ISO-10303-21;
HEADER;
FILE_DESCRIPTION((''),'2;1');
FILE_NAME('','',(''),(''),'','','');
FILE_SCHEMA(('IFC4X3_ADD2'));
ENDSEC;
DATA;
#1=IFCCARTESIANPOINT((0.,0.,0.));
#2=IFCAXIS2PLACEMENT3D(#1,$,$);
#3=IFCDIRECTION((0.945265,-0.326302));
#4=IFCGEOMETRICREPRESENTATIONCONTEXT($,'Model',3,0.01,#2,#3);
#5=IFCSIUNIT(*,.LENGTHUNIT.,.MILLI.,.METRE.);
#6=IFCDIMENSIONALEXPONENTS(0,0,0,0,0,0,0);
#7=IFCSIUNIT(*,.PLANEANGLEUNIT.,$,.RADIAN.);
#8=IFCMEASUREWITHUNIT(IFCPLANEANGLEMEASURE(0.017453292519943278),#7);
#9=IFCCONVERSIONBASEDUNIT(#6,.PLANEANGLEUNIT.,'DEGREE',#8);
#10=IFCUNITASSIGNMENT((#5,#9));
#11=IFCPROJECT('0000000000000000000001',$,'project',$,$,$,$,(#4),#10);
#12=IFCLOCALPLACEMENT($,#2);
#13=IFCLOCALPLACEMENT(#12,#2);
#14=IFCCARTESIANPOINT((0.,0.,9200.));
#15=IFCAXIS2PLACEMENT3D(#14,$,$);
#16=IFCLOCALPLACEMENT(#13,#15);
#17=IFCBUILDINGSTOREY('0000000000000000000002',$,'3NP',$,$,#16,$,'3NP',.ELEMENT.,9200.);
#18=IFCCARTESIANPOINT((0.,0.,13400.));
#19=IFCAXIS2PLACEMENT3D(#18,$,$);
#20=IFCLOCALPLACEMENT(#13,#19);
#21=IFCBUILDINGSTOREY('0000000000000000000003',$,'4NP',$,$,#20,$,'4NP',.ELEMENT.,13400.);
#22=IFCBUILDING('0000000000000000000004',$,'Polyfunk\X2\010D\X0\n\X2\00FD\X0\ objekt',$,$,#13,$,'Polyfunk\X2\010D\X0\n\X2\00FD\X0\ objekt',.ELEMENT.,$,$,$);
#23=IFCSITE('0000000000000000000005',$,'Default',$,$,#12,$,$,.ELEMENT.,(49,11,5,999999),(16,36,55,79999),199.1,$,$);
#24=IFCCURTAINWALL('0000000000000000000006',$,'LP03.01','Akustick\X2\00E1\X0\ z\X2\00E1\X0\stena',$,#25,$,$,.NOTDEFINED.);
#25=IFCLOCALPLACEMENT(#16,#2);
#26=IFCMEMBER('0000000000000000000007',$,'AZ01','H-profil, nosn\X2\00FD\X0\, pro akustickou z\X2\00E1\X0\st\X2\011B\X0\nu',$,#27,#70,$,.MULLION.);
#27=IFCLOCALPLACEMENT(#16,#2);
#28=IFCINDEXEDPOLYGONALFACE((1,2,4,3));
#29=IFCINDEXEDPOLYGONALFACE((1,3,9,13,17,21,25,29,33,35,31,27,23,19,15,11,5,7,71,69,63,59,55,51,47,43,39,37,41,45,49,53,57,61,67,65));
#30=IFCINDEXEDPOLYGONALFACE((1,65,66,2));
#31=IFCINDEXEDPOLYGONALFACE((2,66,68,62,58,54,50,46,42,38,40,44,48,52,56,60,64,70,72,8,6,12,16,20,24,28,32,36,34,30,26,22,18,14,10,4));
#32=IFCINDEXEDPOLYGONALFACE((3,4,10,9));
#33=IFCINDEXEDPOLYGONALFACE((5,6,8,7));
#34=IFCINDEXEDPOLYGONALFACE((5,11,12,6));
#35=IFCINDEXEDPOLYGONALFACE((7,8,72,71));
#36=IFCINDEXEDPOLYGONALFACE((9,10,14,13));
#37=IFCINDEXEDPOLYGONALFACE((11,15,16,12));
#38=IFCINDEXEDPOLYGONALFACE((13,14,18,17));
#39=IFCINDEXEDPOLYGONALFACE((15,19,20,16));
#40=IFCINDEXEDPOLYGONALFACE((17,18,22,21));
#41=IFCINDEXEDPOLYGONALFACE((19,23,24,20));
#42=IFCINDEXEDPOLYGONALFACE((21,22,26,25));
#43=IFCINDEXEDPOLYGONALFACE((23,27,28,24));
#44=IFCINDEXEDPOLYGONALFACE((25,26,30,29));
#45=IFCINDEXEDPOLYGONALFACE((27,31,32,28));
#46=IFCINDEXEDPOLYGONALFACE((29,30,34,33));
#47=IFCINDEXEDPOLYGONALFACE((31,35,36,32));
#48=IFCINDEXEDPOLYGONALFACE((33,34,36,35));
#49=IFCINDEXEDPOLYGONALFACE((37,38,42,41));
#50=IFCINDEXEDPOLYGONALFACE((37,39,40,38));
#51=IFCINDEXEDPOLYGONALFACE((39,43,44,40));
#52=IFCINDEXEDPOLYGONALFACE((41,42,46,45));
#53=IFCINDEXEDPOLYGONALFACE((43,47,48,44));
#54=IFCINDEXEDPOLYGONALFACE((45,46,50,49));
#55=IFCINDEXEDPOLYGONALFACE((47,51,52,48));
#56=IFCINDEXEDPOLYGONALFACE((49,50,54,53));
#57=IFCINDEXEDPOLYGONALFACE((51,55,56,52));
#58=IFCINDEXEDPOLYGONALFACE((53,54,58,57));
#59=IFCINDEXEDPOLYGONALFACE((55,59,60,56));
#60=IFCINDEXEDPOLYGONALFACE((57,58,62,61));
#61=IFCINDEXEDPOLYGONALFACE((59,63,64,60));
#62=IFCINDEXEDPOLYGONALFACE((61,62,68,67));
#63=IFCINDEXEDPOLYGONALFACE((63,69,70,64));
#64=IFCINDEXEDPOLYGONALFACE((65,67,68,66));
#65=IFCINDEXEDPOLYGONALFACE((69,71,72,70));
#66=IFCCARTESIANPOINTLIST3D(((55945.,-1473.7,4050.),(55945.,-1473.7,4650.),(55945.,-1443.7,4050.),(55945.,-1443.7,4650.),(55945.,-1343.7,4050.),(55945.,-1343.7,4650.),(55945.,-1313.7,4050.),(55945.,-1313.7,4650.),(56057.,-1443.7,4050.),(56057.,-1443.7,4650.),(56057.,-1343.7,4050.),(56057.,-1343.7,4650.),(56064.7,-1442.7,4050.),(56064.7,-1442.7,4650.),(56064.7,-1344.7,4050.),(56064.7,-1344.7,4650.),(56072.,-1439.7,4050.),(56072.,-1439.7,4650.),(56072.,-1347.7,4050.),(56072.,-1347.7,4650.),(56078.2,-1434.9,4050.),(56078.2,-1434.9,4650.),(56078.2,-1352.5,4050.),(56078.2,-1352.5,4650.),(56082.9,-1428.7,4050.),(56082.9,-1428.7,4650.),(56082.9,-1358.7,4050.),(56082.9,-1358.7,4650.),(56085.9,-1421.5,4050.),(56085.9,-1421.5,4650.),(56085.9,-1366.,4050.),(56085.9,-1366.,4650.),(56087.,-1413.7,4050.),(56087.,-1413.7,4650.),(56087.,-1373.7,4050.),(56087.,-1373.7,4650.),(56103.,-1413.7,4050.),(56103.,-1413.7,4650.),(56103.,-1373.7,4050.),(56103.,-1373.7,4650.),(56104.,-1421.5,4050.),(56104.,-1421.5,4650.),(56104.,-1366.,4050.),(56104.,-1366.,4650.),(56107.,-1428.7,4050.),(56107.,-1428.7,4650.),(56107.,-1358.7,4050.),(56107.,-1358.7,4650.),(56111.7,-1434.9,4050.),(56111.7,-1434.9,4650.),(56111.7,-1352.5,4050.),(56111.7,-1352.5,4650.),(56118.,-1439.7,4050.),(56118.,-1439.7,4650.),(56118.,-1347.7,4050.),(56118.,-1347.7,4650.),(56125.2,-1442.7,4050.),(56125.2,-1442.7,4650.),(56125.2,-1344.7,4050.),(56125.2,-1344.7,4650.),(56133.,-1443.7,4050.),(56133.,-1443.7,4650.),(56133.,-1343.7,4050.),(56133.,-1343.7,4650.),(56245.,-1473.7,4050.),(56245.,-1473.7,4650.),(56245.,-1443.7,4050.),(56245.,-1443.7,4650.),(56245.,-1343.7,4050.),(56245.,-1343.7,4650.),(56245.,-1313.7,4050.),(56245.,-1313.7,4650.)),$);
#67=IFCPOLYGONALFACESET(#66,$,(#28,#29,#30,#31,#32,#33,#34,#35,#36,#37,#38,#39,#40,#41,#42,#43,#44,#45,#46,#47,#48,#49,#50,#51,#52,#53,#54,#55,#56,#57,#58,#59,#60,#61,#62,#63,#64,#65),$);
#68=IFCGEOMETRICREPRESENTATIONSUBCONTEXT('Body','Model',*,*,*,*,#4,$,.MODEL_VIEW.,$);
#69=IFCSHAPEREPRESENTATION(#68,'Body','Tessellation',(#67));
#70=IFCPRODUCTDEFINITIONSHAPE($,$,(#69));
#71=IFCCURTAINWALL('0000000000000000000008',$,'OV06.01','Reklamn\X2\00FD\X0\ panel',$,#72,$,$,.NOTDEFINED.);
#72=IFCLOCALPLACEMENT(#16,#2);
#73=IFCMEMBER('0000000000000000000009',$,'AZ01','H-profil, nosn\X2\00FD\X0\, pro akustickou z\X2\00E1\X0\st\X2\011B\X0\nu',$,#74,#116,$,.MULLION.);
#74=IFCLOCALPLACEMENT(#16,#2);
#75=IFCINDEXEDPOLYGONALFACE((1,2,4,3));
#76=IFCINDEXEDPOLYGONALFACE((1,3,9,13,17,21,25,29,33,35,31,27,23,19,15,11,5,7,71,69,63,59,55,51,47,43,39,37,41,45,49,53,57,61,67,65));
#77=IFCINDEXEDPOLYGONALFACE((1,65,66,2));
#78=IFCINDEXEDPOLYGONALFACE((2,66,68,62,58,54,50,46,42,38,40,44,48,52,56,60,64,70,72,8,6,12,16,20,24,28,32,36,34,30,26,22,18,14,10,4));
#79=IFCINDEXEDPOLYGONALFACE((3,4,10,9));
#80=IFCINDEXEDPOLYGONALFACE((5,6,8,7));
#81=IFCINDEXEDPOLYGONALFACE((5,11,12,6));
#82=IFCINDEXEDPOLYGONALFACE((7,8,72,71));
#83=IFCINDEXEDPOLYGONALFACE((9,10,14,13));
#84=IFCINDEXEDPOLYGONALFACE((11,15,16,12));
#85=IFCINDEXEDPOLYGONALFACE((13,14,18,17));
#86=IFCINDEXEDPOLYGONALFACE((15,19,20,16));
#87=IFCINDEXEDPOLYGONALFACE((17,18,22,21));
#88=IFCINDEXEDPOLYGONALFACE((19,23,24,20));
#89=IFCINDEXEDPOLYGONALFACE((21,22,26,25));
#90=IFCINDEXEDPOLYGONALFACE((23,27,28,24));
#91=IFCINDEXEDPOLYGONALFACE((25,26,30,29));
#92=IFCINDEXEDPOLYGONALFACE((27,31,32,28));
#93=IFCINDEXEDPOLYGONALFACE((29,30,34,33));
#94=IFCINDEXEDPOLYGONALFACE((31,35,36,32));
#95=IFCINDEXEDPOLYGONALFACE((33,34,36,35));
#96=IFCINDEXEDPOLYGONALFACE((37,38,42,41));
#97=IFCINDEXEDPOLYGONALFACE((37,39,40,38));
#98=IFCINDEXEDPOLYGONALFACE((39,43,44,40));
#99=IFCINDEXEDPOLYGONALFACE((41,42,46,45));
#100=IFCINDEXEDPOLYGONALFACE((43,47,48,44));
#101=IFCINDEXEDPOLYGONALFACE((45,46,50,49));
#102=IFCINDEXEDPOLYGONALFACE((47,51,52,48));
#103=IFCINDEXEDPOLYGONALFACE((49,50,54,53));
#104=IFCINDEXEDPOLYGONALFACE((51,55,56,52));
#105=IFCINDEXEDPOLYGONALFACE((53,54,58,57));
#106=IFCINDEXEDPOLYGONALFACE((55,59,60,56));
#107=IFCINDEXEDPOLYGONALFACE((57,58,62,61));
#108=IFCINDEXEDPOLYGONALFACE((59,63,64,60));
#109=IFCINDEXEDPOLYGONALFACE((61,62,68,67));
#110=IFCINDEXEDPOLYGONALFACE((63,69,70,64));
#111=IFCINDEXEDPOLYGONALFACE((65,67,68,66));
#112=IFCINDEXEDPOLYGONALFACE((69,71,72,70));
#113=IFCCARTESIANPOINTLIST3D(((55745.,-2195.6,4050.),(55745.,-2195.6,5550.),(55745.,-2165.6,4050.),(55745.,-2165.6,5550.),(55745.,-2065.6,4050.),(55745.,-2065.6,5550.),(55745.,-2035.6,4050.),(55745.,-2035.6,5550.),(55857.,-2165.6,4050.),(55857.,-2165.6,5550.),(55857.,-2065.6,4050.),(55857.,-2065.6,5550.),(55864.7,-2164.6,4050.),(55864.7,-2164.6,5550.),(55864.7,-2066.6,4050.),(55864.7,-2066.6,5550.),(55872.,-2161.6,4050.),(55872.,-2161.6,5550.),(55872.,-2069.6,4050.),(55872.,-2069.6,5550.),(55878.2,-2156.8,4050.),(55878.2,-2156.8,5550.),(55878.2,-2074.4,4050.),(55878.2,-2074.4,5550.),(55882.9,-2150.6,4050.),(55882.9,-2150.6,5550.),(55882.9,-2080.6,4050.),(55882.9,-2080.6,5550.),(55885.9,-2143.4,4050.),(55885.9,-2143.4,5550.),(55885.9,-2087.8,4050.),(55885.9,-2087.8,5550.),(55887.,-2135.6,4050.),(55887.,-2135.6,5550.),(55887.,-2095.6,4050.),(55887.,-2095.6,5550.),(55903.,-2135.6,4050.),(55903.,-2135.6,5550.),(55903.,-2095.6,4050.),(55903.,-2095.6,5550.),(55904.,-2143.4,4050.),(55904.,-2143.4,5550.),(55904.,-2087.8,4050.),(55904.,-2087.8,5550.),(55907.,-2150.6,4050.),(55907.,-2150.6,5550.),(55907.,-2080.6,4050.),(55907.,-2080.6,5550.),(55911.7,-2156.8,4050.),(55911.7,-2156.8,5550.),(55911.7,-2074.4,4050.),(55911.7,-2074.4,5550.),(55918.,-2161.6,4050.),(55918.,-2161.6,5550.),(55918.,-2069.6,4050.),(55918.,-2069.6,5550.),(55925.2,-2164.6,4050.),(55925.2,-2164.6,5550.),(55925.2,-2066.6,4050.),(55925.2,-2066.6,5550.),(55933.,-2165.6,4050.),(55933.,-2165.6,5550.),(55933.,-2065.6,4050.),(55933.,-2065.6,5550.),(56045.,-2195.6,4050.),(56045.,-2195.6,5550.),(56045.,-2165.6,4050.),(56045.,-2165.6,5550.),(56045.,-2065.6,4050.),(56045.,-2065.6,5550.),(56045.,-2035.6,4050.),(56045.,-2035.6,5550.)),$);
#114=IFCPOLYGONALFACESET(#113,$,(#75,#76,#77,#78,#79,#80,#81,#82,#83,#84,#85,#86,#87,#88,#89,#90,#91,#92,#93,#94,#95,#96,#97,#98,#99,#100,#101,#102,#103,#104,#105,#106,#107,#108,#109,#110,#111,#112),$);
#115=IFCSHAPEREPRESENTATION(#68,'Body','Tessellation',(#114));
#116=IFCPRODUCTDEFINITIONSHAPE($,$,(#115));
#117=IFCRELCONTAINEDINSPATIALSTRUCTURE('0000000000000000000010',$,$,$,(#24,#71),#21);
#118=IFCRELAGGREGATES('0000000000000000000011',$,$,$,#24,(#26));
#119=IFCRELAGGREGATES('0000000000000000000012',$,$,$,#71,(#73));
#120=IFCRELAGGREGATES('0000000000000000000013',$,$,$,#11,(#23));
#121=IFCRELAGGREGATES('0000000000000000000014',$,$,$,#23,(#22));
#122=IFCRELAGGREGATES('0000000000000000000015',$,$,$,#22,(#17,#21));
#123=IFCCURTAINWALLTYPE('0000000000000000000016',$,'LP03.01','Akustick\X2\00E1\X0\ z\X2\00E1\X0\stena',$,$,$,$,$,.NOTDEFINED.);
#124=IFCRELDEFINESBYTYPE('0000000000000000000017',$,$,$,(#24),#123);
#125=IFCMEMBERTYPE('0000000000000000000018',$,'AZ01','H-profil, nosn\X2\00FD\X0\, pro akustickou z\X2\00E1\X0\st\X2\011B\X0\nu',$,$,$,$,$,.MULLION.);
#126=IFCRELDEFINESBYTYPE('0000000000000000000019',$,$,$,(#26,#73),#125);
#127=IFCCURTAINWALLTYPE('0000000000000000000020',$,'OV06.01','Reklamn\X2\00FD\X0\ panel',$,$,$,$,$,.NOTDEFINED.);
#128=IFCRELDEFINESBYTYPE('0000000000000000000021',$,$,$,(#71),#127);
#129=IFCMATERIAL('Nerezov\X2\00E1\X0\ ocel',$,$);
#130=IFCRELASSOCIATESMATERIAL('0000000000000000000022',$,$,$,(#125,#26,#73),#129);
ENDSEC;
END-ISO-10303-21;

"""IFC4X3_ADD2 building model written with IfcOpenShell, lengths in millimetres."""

from ifc_helpers import new_model, entity, si_unit, converted_unit, direction, frame, frame_2d, origin, place, context, subcontext, project, spatial, polyline, circle_curve, parameter, trimmed, segment, composite_curve, outline, extrude, source, transform, mapped, material, material_profile, profile_set, profile_usage, type_object, element, aggregate, save


model = new_model("IFC4X3_ADD2")

# Units and contexts
model_context = context("Model", 3, precision=0.01, world=origin(), true_north=direction((0.945265, -0.326302)))
body_context = subcontext(model_context, "Body", "Model", "MODEL_VIEW")
ifc_project = project(units=[si_unit("LENGTHUNIT", "METRE", prefix="MILLI"), converted_unit("PLANEANGLEUNIT", "DEGREE", entity("IfcPlaneAngleMeasure", 0.017453292519943278), si_unit("PLANEANGLEUNIT", "RADIAN"), dimensions=[0, 0, 0, 0, 0, 0, 0])], contexts=[model_context])

# Site, building, storey
site_placement = place(None, origin())
site = spatial("IfcSite", under=ifc_project, at=site_placement, Name="Default", CompositionType="ELEMENT", RefLatitude=(49, 11, 5, 999999), RefLongitude=(16, 36, 55, 79999), RefElevation=199.1)
building_placement = place(site_placement, origin())
building = spatial("IfcBuilding", under=site, at=building_placement, Name="Polyfunkčný objekt", LongName="Polyfunkčný objekt", CompositionType="ELEMENT")
storey_1_placement = place(building_placement, frame((0.0, 0.0, 9200.0)))
storey_1 = spatial("IfcBuildingStorey", under=building, at=storey_1_placement, Name="3NP", LongName="3NP", CompositionType="ELEMENT", Elevation=9200.0)

# Shared definitions
storey_2_placement = place(building_placement, frame((0.0, 0.0, 13400.0)))
storey_2 = spatial("IfcBuildingStorey", under=building, at=storey_2_placement, Name="4NP", LongName="4NP", CompositionType="ELEMENT", Elevation=13400.0)

# Curtain walls, members
curtain_wall_type_1 = type_object("IfcCurtainWallType", Name="LP03.01", Description="Akustická zástena", PredefinedType="NOTDEFINED")
ifc_material_1 = material(Name="Nerezová ocel")
ifc_material_profile_1 = material_profile(ifc_material_1, outline(composite_curve([segment(polyline([(50.0, -150.0), (80.0, -150.0)]), True, "CONTINUOUS"), segment(polyline([(80.0, -150.0), (80.0, 150.0)]), True, "CONTINUOUS"), segment(polyline([(80.0, 150.0), (50.0, 150.0)]), True, "CONTINUOUS"), segment(polyline([(50.0, 150.0), (50.0, 38.0)]), True, "CONTINUOUS"), segment(trimmed(circle_curve(frame_2d((20.0, 38.0), x_axis=(0.0, 1.0)), 30.0), [parameter(180.0)], [parameter(270.0)], True, "PARAMETER"), False, "CONTINUOUS"), segment(polyline([(20.0, 8.0), (-20.0, 8.0)]), True, "CONTINUOUS"), segment(trimmed(circle_curve(frame_2d((-20.0, 38.0), x_axis=(0.0, 1.0)), 30.0), [parameter(90.0)], [parameter(180.0)], True, "PARAMETER"), False, "CONTINUOUS"), segment(polyline([(-50.0, 38.0), (-50.0, 150.0)]), True, "CONTINUOUS"), segment(polyline([(-50.0, 150.0), (-80.0, 150.0)]), True, "CONTINUOUS"), segment(polyline([(-80.0, 150.0), (-80.0, -150.0)]), True, "CONTINUOUS"), segment(polyline([(-80.0, -150.0), (-50.0, -150.0)]), True, "CONTINUOUS"), segment(polyline([(-50.0, -150.0), (-50.0, -38.0)]), True, "CONTINUOUS"), segment(trimmed(circle_curve(frame_2d((-20.0, -38.0), x_axis=(0.0, 1.0)), 30.0), [parameter(0.0)], [parameter(90.0)], True, "PARAMETER"), False, "CONTINUOUS"), segment(polyline([(-20.0, -8.0), (20.0, -8.0)]), True, "CONTINUOUS"), segment(trimmed(circle_curve(frame_2d((20.0, -38.0), x_axis=(0.0, 1.0)), 30.0), [parameter(270.0)], [parameter(0.0)], True, "PARAMETER"), False, "CONTINUOUS"), segment(polyline([(50.0, -38.0), (50.0, -150.0)]), True, "CONTINUOUS")], self_intersect=False)), Name="Profil zástena")
ifc_profile_set_1 = profile_set([ifc_material_profile_1], Name="Profil zástena")
ifc_profile_usage_1 = profile_usage(ifc_profile_set_1)
member_type_1 = type_object("IfcMemberType", Name="AZ01", Description="H-profil, nosný, pro akustickou zástěnu", PredefinedType="MULLION", material=ifc_profile_set_1)
curtain_wall_1_placement = place(storey_2_placement, frame((0.0, 0.0, -13400.0)))
curtain_wall_1 = element("IfcCurtainWall", 1, at=curtain_wall_1_placement, inside=storey_2, type_object=curtain_wall_type_1, Name="LP03.01", Description="Akustická zástena", PredefinedType="NOTDEFINED")
shared_shape_1 = source(origin(), body_context, "Body", "SweptSolid", [
    extrude(outline(composite_curve([segment(polyline([(50.0, -150.0), (80.0, -150.0)]), True, "CONTINUOUS"), segment(polyline([(80.0, -150.0), (80.0, 150.0)]), True, "CONTINUOUS"), segment(polyline([(80.0, 150.0), (50.0, 150.0)]), True, "CONTINUOUS"), segment(polyline([(50.0, 150.0), (50.0, 38.0)]), True, "CONTINUOUS"), segment(trimmed(circle_curve(frame_2d((20.0, 38.0), x_axis=(0.0, 1.0)), 30.0), [parameter(180.0)], [parameter(270.0)], True, "PARAMETER"), False, "CONTINUOUS"), segment(polyline([(20.0, 8.0), (-20.0, 8.0)]), True, "CONTINUOUS"), segment(trimmed(circle_curve(frame_2d((-20.0, 38.0), x_axis=(0.0, 1.0)), 30.0), [parameter(90.0)], [parameter(180.0)], True, "PARAMETER"), False, "CONTINUOUS"), segment(polyline([(-50.0, 38.0), (-50.0, 150.0)]), True, "CONTINUOUS"), segment(polyline([(-50.0, 150.0), (-80.0, 150.0)]), True, "CONTINUOUS"), segment(polyline([(-80.0, 150.0), (-80.0, -150.0)]), True, "CONTINUOUS"), segment(polyline([(-80.0, -150.0), (-50.0, -150.0)]), True, "CONTINUOUS"), segment(polyline([(-50.0, -150.0), (-50.0, -38.0)]), True, "CONTINUOUS"), segment(trimmed(circle_curve(frame_2d((-20.0, -38.0), x_axis=(0.0, 1.0)), 30.0), [parameter(0.0)], [parameter(90.0)], True, "PARAMETER"), False, "CONTINUOUS"), segment(polyline([(-20.0, -8.0), (20.0, -8.0)]), True, "CONTINUOUS"), segment(trimmed(circle_curve(frame_2d((20.0, -38.0), x_axis=(0.0, 1.0)), 30.0), [parameter(270.0)], [parameter(0.0)], True, "PARAMETER"), False, "CONTINUOUS"), segment(polyline([(50.0, -38.0), (50.0, -150.0)]), True, "CONTINUOUS")], self_intersect=False)), frame((-150.0, 0.0, -600.0), z_axis=(0.0, 0.0, 1.0), x_axis=(0.0, -1.0, 0.0)), (0.0, 0.0, 1.0), 600.0),
])
member_1_placement = place(curtain_wall_1_placement, frame((56245.0, -1393.7, 13250.0), z_axis=(0.0, 0.0, -1.0), x_axis=(1.0, 0.0, 0.0)))
member_1 = element("IfcMember", 2, at=member_1_placement, type_object=member_type_1, material=ifc_profile_usage_1, Name="AZ01", Description="H-profil, nosný, pro akustickou zástěnu", PredefinedType="MULLION", context=body_context, shape_type="MappedRepresentation", body=[
    mapped(shared_shape_1, transform((0.0, 0.0, 0.0), scale=1.0)),
])
aggregate(curtain_wall_1, [member_1])
curtain_wall_type_2 = type_object("IfcCurtainWallType", Name="OV06.01", Description="Reklamný panel", PredefinedType="NOTDEFINED")
curtain_wall_2_placement = place(storey_2_placement, frame((0.0, 0.0, -13400.0)))
curtain_wall_2 = element("IfcCurtainWall", 3, at=curtain_wall_2_placement, inside=storey_2, type_object=curtain_wall_type_2, Name="OV06.01", Description="Reklamný panel", PredefinedType="NOTDEFINED")
shared_shape_2 = source(origin(), body_context, "Body", "SweptSolid", [
    extrude(outline(composite_curve([segment(polyline([(-150.0, -50.0), (-150.0, -80.0)]), True, "CONTINUOUS"), segment(polyline([(-150.0, -80.0), (150.0, -80.0)]), True, "CONTINUOUS"), segment(polyline([(150.0, -80.0), (150.0, -50.0)]), True, "CONTINUOUS"), segment(polyline([(150.0, -50.0), (38.0, -50.0)]), True, "CONTINUOUS"), segment(trimmed(circle_curve(frame_2d((38.0, -20.0), x_axis=(1.0, 0.0)), 30.0), [parameter(180.0)], [parameter(270.0)], True, "PARAMETER"), False, "CONTINUOUS"), segment(polyline([(8.0, -20.0), (8.0, 20.0)]), True, "CONTINUOUS"), segment(trimmed(circle_curve(frame_2d((38.0, 20.0), x_axis=(1.0, 0.0)), 30.0), [parameter(90.0)], [parameter(180.0)], True, "PARAMETER"), False, "CONTINUOUS"), segment(polyline([(38.0, 50.0), (150.0, 50.0)]), True, "CONTINUOUS"), segment(polyline([(150.0, 50.0), (150.0, 80.0)]), True, "CONTINUOUS"), segment(polyline([(150.0, 80.0), (-150.0, 80.0)]), True, "CONTINUOUS"), segment(polyline([(-150.0, 80.0), (-150.0, 50.0)]), True, "CONTINUOUS"), segment(polyline([(-150.0, 50.0), (-38.0, 50.0)]), True, "CONTINUOUS"), segment(trimmed(circle_curve(frame_2d((-38.0, 20.0), x_axis=(1.0, 0.0)), 30.0), [parameter(0.0)], [parameter(90.0)], True, "PARAMETER"), False, "CONTINUOUS"), segment(polyline([(-8.0, 20.0), (-8.0, -20.0)]), True, "CONTINUOUS"), segment(trimmed(circle_curve(frame_2d((-38.0, -20.0), x_axis=(1.0, 0.0)), 30.0), [parameter(270.0)], [parameter(0.0)], True, "PARAMETER"), False, "CONTINUOUS"), segment(polyline([(-38.0, -50.0), (-150.0, -50.0)]), True, "CONTINUOUS")], self_intersect=False)), frame((-150.0, 0.0, -1500.0), z_axis=(0.0, 0.0, -1.0), x_axis=(1.0, 0.0, 0.0)), (0.0, 0.0, -1.0), 1500.0),
])
member_2_placement = place(curtain_wall_2_placement, frame((56045.0, -2115.6, 13250.0), z_axis=(0.0, 0.0, -1.0), x_axis=(1.0, 0.0, 0.0)))
member_2 = element("IfcMember", 4, at=member_2_placement, type_object=member_type_1, material=ifc_profile_usage_1, Name="AZ01", Description="H-profil, nosný, pro akustickou zástěnu", PredefinedType="MULLION", context=body_context, shape_type="MappedRepresentation", body=[
    mapped(shared_shape_2, transform((0.0, 0.0, 0.0), scale=1.0)),
])
aggregate(curtain_wall_2, [member_2])

save(model, "model.ifc")
